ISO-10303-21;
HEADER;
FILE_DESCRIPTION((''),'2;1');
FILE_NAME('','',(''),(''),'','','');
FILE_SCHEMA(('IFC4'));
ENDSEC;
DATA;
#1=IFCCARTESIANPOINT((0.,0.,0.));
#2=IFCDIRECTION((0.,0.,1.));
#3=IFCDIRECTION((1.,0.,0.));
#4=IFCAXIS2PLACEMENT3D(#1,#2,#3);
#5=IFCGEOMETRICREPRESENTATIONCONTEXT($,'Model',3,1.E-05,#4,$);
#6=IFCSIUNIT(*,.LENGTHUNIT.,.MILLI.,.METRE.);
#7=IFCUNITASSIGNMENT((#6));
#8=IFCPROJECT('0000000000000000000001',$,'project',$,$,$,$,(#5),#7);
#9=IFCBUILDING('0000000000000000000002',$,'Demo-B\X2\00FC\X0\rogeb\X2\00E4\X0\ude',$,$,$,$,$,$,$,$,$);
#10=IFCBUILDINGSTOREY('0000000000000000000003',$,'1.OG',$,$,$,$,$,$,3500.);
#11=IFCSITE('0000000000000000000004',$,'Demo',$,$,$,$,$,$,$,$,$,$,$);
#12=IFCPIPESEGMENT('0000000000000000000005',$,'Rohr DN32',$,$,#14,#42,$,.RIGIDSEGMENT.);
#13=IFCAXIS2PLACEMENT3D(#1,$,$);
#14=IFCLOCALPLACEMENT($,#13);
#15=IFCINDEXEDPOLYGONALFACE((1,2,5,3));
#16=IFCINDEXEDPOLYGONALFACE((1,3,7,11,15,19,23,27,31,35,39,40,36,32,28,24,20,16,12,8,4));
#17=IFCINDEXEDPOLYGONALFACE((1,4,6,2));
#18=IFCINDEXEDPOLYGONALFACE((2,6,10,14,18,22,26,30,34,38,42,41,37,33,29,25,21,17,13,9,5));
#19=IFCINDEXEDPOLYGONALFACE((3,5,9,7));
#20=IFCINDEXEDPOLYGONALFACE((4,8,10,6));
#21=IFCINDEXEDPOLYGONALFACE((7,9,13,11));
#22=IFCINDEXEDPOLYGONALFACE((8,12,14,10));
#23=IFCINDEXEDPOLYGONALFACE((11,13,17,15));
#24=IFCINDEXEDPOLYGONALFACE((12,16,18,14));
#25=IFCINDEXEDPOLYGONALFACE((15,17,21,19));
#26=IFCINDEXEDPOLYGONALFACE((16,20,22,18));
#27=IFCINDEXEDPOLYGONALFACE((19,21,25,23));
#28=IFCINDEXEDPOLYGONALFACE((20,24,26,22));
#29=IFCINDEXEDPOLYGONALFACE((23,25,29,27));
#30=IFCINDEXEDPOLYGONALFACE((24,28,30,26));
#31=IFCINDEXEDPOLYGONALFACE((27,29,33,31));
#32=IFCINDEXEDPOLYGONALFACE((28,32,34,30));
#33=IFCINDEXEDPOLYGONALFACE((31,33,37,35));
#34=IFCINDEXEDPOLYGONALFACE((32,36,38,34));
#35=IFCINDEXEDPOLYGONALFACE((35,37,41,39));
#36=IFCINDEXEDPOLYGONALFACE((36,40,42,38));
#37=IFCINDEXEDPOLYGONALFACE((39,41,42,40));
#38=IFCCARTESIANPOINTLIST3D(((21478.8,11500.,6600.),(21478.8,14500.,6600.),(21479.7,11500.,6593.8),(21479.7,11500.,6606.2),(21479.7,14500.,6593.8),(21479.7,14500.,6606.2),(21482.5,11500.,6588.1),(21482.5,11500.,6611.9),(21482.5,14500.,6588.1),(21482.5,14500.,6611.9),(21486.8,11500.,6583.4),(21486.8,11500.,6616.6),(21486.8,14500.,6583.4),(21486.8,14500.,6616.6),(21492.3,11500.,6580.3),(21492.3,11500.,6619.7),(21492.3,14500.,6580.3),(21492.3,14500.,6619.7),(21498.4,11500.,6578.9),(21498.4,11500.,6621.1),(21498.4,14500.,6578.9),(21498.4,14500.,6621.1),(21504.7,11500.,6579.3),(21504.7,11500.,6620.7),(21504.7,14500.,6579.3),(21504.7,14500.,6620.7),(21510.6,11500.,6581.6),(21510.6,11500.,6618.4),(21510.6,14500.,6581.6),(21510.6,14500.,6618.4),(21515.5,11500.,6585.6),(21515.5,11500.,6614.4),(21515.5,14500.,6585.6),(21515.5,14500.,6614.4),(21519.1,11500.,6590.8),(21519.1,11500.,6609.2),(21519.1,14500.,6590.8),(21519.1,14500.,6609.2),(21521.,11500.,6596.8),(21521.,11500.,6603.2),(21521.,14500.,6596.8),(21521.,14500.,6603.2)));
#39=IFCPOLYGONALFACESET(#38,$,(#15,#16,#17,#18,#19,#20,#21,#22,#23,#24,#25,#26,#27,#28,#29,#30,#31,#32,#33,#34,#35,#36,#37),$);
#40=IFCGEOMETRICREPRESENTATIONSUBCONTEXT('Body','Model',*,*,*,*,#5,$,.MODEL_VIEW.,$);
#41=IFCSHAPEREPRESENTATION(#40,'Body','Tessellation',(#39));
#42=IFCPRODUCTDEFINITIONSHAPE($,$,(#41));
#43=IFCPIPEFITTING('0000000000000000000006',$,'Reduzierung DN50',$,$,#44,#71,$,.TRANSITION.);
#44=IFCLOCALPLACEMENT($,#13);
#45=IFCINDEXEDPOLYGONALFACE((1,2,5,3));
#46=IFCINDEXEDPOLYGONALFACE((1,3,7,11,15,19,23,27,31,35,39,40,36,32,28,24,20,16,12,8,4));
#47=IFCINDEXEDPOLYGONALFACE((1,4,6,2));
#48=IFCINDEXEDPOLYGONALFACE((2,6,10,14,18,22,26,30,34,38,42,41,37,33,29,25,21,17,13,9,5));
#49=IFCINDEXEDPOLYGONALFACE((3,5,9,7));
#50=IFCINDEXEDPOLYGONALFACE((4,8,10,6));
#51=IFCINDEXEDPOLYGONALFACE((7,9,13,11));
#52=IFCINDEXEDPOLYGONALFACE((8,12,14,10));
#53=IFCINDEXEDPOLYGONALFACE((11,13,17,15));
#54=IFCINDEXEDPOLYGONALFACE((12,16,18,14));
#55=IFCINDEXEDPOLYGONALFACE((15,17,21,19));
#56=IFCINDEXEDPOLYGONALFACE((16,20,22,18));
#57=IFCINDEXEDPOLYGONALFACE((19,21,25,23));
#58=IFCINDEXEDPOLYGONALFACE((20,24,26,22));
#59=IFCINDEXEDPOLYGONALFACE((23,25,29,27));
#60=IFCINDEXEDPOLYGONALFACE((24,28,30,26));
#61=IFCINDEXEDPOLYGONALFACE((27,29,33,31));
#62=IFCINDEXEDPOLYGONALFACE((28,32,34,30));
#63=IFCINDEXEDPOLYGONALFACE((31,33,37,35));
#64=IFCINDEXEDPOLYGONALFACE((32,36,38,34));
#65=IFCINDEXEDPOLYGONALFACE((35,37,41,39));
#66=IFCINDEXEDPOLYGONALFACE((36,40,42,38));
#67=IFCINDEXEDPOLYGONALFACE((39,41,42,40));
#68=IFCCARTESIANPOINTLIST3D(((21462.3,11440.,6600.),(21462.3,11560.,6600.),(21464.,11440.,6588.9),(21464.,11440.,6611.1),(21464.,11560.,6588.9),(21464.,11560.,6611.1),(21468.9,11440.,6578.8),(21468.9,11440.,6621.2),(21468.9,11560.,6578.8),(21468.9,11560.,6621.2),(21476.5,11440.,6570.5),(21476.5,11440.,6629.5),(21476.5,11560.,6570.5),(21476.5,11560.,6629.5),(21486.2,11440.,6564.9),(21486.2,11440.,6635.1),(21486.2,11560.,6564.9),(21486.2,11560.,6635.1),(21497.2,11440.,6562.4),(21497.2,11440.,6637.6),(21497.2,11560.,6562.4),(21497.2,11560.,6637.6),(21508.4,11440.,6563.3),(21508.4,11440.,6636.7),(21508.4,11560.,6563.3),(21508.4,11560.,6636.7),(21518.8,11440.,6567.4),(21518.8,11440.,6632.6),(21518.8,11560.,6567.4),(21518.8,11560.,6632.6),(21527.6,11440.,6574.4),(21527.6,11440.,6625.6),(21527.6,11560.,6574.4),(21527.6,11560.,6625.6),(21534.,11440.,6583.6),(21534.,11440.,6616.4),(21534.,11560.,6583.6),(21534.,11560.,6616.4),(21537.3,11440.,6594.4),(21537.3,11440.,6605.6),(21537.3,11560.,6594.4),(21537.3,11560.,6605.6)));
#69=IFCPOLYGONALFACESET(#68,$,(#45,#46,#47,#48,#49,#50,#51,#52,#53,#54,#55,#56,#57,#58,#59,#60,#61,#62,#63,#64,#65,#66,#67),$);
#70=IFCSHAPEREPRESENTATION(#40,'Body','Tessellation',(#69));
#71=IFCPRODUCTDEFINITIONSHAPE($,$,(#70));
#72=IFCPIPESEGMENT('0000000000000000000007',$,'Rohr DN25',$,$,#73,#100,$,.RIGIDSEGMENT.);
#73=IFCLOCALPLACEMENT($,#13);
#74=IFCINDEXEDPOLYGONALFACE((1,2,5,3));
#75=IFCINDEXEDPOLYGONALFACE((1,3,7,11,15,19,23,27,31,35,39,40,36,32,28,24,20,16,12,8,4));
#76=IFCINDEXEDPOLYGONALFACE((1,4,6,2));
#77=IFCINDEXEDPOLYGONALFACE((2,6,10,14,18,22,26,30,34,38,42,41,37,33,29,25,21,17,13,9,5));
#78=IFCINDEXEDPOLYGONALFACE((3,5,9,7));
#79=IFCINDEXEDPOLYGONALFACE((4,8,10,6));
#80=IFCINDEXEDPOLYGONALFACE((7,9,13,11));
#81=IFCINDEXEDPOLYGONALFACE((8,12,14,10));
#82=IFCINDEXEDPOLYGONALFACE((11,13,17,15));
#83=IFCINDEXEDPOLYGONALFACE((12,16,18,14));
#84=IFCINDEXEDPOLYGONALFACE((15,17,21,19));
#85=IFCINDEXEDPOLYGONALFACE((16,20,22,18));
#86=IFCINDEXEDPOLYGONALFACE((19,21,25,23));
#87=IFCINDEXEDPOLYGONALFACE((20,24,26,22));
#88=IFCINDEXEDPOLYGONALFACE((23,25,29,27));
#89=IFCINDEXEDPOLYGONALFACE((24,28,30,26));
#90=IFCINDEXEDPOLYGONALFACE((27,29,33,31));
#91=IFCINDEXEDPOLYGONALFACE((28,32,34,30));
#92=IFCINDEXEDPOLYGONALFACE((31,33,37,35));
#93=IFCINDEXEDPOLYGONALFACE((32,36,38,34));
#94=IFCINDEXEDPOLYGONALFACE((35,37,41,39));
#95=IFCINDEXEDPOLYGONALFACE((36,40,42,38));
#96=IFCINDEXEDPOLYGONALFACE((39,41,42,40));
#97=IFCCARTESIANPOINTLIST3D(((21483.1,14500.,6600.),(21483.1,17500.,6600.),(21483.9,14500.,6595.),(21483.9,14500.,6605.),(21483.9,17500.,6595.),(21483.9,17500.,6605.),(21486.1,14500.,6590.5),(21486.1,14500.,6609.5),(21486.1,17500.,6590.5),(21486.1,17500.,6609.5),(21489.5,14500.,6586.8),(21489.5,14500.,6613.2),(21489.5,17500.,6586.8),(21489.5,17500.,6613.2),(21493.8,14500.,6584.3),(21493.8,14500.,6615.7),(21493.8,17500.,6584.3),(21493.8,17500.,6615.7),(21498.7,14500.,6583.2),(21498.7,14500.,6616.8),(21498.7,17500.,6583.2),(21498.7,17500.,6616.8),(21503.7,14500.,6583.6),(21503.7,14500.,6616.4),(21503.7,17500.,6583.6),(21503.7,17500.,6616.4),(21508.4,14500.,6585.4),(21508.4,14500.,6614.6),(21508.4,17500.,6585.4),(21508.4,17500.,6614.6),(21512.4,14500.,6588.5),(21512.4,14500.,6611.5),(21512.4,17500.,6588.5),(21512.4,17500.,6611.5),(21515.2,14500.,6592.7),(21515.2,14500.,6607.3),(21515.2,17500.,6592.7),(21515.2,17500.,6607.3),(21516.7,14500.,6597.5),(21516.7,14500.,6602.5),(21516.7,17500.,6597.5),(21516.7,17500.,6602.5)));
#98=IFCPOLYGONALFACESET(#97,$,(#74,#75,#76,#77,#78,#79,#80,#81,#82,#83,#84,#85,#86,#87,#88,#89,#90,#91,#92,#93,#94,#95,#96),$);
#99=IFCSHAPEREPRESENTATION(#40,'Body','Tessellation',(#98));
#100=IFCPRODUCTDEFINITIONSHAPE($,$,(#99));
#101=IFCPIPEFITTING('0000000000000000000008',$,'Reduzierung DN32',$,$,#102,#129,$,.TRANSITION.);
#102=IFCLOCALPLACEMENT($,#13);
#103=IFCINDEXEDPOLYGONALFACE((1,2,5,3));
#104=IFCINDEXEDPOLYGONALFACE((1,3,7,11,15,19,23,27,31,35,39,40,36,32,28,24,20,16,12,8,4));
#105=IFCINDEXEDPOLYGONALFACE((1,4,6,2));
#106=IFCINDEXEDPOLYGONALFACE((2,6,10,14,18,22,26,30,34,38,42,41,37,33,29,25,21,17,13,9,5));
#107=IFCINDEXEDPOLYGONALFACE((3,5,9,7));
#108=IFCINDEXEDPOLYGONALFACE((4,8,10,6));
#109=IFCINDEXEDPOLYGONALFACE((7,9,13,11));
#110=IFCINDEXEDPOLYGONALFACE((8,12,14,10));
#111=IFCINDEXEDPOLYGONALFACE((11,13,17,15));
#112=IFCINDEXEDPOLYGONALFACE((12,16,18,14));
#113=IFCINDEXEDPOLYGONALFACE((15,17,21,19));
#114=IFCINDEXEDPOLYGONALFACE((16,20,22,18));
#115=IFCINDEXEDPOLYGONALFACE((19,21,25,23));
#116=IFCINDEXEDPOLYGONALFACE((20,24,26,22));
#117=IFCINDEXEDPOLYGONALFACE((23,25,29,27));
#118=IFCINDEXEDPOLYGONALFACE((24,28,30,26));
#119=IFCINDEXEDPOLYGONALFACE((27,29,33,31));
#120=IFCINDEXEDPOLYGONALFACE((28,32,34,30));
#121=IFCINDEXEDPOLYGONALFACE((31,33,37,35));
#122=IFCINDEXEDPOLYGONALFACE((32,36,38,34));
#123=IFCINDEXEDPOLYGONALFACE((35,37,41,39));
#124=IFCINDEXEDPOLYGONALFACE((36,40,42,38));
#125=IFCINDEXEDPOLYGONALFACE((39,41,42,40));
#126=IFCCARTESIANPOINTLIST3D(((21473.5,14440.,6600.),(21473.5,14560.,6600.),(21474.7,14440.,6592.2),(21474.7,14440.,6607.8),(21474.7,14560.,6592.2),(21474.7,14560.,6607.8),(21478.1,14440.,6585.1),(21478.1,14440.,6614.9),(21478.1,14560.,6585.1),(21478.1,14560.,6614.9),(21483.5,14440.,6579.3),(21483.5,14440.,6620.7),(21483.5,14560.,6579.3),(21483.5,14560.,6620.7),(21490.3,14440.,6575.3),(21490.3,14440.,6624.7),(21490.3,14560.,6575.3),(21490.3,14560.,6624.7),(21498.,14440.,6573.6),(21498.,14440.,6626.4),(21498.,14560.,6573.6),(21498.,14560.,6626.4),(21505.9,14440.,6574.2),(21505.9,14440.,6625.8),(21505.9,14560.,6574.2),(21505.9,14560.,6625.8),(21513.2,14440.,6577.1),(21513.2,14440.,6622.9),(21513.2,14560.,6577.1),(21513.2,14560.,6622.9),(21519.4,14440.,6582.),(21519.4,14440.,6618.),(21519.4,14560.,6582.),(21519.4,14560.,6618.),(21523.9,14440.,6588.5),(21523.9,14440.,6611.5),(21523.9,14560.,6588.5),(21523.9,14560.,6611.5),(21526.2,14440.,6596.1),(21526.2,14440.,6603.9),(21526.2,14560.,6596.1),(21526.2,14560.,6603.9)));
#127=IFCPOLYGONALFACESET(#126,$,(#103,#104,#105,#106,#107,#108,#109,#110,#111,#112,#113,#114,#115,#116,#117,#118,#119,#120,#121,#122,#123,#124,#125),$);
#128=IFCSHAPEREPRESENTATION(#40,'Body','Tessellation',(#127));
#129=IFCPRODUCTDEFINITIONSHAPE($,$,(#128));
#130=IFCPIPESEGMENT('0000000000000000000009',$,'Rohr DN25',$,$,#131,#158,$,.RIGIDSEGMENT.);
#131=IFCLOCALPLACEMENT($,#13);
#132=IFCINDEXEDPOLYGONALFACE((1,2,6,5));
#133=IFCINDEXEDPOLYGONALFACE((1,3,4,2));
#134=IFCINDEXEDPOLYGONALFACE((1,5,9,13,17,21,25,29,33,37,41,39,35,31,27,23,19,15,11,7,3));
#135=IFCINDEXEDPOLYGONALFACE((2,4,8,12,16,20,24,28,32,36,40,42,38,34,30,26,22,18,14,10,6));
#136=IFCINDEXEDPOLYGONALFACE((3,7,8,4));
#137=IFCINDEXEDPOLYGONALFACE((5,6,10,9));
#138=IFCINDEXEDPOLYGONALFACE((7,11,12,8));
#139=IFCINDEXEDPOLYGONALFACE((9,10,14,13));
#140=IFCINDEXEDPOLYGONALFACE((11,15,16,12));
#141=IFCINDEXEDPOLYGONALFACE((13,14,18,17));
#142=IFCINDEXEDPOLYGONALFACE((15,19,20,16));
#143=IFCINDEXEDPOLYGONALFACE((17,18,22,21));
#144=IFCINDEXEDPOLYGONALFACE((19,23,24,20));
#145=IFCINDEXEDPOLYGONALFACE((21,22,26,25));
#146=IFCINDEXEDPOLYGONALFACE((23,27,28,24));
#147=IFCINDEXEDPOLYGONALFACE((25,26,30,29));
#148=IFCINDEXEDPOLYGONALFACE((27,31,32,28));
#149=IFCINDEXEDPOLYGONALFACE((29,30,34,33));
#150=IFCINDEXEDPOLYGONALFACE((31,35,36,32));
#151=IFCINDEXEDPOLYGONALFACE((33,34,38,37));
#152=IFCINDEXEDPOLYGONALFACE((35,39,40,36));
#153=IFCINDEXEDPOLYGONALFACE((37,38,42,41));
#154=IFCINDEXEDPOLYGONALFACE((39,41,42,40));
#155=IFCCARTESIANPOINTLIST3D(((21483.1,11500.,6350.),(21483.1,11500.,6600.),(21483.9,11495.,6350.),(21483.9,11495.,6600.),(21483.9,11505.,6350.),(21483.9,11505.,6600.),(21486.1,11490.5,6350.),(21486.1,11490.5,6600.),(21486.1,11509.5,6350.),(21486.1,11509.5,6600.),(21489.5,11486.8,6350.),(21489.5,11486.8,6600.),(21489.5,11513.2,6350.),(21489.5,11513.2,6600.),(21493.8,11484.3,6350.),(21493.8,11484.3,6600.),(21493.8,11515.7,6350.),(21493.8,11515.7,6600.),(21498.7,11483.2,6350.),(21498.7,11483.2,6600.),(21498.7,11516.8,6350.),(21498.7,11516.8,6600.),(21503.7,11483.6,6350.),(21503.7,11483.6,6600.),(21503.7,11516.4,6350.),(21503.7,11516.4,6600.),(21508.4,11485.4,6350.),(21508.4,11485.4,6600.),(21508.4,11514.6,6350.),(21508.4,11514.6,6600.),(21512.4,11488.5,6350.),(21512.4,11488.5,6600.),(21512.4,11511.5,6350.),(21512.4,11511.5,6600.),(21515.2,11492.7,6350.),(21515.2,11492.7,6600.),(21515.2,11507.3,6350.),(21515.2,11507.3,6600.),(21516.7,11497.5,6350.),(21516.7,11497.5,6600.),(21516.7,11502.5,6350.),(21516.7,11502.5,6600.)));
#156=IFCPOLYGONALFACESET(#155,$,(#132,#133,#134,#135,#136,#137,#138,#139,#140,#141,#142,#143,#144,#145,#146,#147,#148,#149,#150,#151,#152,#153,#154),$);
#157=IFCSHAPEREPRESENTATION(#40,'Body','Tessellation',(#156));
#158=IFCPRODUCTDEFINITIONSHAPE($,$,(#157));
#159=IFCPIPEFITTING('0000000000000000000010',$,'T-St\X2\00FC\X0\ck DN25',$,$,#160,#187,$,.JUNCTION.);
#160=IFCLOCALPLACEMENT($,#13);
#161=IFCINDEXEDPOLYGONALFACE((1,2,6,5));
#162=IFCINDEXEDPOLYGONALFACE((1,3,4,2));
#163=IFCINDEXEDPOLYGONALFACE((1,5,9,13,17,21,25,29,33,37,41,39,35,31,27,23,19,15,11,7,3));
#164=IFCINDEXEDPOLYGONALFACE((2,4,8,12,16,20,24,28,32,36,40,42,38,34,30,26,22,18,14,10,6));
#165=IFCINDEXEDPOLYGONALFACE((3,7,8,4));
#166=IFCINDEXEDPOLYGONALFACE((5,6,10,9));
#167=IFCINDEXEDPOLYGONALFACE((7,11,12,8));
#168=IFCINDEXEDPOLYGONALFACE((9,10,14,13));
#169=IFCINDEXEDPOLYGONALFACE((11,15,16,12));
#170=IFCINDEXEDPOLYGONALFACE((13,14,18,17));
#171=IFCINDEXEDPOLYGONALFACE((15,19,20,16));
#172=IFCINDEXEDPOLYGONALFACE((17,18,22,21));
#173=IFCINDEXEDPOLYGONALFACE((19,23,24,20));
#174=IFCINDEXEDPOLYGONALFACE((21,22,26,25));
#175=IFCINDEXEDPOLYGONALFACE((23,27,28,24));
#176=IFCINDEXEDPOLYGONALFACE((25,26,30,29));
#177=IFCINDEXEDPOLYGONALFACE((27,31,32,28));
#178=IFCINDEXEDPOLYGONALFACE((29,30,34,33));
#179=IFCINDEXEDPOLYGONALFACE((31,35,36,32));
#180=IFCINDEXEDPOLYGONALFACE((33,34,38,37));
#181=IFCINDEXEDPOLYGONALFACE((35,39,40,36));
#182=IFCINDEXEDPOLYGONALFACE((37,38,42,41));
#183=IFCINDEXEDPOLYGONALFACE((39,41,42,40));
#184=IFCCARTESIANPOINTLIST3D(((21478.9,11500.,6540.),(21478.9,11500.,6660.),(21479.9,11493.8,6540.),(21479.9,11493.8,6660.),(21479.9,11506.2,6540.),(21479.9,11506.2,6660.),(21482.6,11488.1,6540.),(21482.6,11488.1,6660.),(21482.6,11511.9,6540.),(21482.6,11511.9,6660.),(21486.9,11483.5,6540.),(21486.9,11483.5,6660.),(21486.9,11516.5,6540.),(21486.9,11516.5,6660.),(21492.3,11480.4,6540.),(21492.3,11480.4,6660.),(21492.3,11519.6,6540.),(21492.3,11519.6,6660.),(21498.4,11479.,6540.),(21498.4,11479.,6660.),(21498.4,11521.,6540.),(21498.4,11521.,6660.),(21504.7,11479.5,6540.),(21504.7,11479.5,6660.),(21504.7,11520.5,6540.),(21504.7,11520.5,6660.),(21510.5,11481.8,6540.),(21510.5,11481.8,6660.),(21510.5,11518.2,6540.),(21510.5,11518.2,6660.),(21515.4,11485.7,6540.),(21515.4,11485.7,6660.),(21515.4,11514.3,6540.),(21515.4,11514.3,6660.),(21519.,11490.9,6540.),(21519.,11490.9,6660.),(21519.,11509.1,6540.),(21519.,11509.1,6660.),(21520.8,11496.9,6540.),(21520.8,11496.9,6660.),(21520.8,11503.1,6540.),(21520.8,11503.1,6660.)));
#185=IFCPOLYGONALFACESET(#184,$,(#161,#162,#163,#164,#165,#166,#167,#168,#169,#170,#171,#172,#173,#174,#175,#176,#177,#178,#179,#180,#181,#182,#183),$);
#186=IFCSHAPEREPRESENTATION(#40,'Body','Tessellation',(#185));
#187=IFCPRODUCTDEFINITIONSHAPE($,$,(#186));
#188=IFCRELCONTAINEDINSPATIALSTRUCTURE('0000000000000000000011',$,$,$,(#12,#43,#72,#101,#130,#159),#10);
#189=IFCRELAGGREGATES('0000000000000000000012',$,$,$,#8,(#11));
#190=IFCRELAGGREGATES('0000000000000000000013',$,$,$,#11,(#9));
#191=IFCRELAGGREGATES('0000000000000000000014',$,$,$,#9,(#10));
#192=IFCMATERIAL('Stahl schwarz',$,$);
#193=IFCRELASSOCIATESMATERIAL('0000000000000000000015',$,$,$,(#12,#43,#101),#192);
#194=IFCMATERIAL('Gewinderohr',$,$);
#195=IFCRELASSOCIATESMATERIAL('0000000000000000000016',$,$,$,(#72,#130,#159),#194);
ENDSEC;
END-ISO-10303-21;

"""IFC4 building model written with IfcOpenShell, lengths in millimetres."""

from ifc_helpers import new_model, si_unit, frame, origin_with_axes, place, context, subcontext, project, spatial, circle, extrude, material, element, save


model = new_model("IFC4")

# Units and contexts
model_context = context("Model", 3, precision=1e-05, world=origin_with_axes())
body_context = subcontext(model_context, "Body", "Model", "MODEL_VIEW")
ifc_project = project(units=[si_unit("LENGTHUNIT", "METRE", prefix="MILLI")], contexts=[model_context])

# Site, building, storey
site = spatial("IfcSite", under=ifc_project, Name="Demo")
building = spatial("IfcBuilding", under=site, Name="Demo-Bürogebäude")
storey = spatial("IfcBuildingStorey", under=building, Name="1.OG", Elevation=3500.0)

# Pipe segment
ifc_material_1 = material(Name="Stahl schwarz")
pipe_segment_1_placement = place(None, frame((21500.0, 11500.0, 6600.0), z_axis=(0.0, 1.0, 0.0), x_axis=(-1.0, 0.0, 0.0)))
element("IfcPipeSegment", 1, at=pipe_segment_1_placement, inside=storey, material=ifc_material_1, Name="Rohr DN32", PredefinedType="RIGIDSEGMENT", context=body_context, shape_type="SweptSolid", body=[
    extrude(circle(Radius=21.2), origin_with_axes(), (0.0, 0.0, 1.0), 3000.0),
])

# Pipe fitting
pipe_fitting_1_placement = place(None, frame((21500.0, 11440.0, 6600.0), z_axis=(0.0, 1.0, 0.0), x_axis=(-1.0, 0.0, 0.0)))
element("IfcPipeFitting", 2, at=pipe_fitting_1_placement, inside=storey, material=ifc_material_1, Name="Reduzierung DN50", PredefinedType="TRANSITION", context=body_context, shape_type="SweptSolid", body=[
    extrude(circle(Radius=37.7), origin_with_axes(), (0.0, 0.0, 1.0), 120.0),
])

# Pipe segment
ifc_material_2 = material(Name="Gewinderohr")
pipe_segment_2_placement = place(None, frame((21500.0, 14500.0, 6600.0), z_axis=(0.0, 1.0, 0.0), x_axis=(-1.0, 0.0, 0.0)))
element("IfcPipeSegment", 3, at=pipe_segment_2_placement, inside=storey, material=ifc_material_2, Name="Rohr DN25", PredefinedType="RIGIDSEGMENT", context=body_context, shape_type="SweptSolid", body=[
    extrude(circle(Radius=16.9), origin_with_axes(), (0.0, 0.0, 1.0), 3000.0),
])

# Pipe fitting
pipe_fitting_2_placement = place(None, frame((21500.0, 14440.0, 6600.0), z_axis=(0.0, 1.0, 0.0), x_axis=(-1.0, 0.0, 0.0)))
element("IfcPipeFitting", 4, at=pipe_fitting_2_placement, inside=storey, material=ifc_material_1, Name="Reduzierung DN32", PredefinedType="TRANSITION", context=body_context, shape_type="SweptSolid", body=[
    extrude(circle(Radius=26.5), origin_with_axes(), (0.0, 0.0, 1.0), 120.0),
])

# Pipe segment
pipe_segment_3_placement = place(None, frame((21500.0, 11500.0, 6600.0), z_axis=(0.0, 0.0, -1.0), x_axis=(-1.0, 0.0, 0.0)))
element("IfcPipeSegment", 5, at=pipe_segment_3_placement, inside=storey, material=ifc_material_2, Name="Rohr DN25", PredefinedType="RIGIDSEGMENT", context=body_context, shape_type="SweptSolid", body=[
    extrude(circle(Radius=16.9), origin_with_axes(), (0.0, 0.0, 1.0), 250.0),
])

# Pipe fitting
pipe_fitting_3_placement = place(None, frame((21500.0, 11500.0, 6660.0), z_axis=(0.0, 0.0, -1.0), x_axis=(-1.0, 0.0, 0.0)))
element("IfcPipeFitting", 6, at=pipe_fitting_3_placement, inside=storey, material=ifc_material_2, Name="T-Stück DN25", PredefinedType="JUNCTION", context=body_context, shape_type="SweptSolid", body=[
    extrude(circle(Radius=21.1), origin_with_axes(), (0.0, 0.0, 1.0), 120.0),
])

save(model, "model.ifc")
